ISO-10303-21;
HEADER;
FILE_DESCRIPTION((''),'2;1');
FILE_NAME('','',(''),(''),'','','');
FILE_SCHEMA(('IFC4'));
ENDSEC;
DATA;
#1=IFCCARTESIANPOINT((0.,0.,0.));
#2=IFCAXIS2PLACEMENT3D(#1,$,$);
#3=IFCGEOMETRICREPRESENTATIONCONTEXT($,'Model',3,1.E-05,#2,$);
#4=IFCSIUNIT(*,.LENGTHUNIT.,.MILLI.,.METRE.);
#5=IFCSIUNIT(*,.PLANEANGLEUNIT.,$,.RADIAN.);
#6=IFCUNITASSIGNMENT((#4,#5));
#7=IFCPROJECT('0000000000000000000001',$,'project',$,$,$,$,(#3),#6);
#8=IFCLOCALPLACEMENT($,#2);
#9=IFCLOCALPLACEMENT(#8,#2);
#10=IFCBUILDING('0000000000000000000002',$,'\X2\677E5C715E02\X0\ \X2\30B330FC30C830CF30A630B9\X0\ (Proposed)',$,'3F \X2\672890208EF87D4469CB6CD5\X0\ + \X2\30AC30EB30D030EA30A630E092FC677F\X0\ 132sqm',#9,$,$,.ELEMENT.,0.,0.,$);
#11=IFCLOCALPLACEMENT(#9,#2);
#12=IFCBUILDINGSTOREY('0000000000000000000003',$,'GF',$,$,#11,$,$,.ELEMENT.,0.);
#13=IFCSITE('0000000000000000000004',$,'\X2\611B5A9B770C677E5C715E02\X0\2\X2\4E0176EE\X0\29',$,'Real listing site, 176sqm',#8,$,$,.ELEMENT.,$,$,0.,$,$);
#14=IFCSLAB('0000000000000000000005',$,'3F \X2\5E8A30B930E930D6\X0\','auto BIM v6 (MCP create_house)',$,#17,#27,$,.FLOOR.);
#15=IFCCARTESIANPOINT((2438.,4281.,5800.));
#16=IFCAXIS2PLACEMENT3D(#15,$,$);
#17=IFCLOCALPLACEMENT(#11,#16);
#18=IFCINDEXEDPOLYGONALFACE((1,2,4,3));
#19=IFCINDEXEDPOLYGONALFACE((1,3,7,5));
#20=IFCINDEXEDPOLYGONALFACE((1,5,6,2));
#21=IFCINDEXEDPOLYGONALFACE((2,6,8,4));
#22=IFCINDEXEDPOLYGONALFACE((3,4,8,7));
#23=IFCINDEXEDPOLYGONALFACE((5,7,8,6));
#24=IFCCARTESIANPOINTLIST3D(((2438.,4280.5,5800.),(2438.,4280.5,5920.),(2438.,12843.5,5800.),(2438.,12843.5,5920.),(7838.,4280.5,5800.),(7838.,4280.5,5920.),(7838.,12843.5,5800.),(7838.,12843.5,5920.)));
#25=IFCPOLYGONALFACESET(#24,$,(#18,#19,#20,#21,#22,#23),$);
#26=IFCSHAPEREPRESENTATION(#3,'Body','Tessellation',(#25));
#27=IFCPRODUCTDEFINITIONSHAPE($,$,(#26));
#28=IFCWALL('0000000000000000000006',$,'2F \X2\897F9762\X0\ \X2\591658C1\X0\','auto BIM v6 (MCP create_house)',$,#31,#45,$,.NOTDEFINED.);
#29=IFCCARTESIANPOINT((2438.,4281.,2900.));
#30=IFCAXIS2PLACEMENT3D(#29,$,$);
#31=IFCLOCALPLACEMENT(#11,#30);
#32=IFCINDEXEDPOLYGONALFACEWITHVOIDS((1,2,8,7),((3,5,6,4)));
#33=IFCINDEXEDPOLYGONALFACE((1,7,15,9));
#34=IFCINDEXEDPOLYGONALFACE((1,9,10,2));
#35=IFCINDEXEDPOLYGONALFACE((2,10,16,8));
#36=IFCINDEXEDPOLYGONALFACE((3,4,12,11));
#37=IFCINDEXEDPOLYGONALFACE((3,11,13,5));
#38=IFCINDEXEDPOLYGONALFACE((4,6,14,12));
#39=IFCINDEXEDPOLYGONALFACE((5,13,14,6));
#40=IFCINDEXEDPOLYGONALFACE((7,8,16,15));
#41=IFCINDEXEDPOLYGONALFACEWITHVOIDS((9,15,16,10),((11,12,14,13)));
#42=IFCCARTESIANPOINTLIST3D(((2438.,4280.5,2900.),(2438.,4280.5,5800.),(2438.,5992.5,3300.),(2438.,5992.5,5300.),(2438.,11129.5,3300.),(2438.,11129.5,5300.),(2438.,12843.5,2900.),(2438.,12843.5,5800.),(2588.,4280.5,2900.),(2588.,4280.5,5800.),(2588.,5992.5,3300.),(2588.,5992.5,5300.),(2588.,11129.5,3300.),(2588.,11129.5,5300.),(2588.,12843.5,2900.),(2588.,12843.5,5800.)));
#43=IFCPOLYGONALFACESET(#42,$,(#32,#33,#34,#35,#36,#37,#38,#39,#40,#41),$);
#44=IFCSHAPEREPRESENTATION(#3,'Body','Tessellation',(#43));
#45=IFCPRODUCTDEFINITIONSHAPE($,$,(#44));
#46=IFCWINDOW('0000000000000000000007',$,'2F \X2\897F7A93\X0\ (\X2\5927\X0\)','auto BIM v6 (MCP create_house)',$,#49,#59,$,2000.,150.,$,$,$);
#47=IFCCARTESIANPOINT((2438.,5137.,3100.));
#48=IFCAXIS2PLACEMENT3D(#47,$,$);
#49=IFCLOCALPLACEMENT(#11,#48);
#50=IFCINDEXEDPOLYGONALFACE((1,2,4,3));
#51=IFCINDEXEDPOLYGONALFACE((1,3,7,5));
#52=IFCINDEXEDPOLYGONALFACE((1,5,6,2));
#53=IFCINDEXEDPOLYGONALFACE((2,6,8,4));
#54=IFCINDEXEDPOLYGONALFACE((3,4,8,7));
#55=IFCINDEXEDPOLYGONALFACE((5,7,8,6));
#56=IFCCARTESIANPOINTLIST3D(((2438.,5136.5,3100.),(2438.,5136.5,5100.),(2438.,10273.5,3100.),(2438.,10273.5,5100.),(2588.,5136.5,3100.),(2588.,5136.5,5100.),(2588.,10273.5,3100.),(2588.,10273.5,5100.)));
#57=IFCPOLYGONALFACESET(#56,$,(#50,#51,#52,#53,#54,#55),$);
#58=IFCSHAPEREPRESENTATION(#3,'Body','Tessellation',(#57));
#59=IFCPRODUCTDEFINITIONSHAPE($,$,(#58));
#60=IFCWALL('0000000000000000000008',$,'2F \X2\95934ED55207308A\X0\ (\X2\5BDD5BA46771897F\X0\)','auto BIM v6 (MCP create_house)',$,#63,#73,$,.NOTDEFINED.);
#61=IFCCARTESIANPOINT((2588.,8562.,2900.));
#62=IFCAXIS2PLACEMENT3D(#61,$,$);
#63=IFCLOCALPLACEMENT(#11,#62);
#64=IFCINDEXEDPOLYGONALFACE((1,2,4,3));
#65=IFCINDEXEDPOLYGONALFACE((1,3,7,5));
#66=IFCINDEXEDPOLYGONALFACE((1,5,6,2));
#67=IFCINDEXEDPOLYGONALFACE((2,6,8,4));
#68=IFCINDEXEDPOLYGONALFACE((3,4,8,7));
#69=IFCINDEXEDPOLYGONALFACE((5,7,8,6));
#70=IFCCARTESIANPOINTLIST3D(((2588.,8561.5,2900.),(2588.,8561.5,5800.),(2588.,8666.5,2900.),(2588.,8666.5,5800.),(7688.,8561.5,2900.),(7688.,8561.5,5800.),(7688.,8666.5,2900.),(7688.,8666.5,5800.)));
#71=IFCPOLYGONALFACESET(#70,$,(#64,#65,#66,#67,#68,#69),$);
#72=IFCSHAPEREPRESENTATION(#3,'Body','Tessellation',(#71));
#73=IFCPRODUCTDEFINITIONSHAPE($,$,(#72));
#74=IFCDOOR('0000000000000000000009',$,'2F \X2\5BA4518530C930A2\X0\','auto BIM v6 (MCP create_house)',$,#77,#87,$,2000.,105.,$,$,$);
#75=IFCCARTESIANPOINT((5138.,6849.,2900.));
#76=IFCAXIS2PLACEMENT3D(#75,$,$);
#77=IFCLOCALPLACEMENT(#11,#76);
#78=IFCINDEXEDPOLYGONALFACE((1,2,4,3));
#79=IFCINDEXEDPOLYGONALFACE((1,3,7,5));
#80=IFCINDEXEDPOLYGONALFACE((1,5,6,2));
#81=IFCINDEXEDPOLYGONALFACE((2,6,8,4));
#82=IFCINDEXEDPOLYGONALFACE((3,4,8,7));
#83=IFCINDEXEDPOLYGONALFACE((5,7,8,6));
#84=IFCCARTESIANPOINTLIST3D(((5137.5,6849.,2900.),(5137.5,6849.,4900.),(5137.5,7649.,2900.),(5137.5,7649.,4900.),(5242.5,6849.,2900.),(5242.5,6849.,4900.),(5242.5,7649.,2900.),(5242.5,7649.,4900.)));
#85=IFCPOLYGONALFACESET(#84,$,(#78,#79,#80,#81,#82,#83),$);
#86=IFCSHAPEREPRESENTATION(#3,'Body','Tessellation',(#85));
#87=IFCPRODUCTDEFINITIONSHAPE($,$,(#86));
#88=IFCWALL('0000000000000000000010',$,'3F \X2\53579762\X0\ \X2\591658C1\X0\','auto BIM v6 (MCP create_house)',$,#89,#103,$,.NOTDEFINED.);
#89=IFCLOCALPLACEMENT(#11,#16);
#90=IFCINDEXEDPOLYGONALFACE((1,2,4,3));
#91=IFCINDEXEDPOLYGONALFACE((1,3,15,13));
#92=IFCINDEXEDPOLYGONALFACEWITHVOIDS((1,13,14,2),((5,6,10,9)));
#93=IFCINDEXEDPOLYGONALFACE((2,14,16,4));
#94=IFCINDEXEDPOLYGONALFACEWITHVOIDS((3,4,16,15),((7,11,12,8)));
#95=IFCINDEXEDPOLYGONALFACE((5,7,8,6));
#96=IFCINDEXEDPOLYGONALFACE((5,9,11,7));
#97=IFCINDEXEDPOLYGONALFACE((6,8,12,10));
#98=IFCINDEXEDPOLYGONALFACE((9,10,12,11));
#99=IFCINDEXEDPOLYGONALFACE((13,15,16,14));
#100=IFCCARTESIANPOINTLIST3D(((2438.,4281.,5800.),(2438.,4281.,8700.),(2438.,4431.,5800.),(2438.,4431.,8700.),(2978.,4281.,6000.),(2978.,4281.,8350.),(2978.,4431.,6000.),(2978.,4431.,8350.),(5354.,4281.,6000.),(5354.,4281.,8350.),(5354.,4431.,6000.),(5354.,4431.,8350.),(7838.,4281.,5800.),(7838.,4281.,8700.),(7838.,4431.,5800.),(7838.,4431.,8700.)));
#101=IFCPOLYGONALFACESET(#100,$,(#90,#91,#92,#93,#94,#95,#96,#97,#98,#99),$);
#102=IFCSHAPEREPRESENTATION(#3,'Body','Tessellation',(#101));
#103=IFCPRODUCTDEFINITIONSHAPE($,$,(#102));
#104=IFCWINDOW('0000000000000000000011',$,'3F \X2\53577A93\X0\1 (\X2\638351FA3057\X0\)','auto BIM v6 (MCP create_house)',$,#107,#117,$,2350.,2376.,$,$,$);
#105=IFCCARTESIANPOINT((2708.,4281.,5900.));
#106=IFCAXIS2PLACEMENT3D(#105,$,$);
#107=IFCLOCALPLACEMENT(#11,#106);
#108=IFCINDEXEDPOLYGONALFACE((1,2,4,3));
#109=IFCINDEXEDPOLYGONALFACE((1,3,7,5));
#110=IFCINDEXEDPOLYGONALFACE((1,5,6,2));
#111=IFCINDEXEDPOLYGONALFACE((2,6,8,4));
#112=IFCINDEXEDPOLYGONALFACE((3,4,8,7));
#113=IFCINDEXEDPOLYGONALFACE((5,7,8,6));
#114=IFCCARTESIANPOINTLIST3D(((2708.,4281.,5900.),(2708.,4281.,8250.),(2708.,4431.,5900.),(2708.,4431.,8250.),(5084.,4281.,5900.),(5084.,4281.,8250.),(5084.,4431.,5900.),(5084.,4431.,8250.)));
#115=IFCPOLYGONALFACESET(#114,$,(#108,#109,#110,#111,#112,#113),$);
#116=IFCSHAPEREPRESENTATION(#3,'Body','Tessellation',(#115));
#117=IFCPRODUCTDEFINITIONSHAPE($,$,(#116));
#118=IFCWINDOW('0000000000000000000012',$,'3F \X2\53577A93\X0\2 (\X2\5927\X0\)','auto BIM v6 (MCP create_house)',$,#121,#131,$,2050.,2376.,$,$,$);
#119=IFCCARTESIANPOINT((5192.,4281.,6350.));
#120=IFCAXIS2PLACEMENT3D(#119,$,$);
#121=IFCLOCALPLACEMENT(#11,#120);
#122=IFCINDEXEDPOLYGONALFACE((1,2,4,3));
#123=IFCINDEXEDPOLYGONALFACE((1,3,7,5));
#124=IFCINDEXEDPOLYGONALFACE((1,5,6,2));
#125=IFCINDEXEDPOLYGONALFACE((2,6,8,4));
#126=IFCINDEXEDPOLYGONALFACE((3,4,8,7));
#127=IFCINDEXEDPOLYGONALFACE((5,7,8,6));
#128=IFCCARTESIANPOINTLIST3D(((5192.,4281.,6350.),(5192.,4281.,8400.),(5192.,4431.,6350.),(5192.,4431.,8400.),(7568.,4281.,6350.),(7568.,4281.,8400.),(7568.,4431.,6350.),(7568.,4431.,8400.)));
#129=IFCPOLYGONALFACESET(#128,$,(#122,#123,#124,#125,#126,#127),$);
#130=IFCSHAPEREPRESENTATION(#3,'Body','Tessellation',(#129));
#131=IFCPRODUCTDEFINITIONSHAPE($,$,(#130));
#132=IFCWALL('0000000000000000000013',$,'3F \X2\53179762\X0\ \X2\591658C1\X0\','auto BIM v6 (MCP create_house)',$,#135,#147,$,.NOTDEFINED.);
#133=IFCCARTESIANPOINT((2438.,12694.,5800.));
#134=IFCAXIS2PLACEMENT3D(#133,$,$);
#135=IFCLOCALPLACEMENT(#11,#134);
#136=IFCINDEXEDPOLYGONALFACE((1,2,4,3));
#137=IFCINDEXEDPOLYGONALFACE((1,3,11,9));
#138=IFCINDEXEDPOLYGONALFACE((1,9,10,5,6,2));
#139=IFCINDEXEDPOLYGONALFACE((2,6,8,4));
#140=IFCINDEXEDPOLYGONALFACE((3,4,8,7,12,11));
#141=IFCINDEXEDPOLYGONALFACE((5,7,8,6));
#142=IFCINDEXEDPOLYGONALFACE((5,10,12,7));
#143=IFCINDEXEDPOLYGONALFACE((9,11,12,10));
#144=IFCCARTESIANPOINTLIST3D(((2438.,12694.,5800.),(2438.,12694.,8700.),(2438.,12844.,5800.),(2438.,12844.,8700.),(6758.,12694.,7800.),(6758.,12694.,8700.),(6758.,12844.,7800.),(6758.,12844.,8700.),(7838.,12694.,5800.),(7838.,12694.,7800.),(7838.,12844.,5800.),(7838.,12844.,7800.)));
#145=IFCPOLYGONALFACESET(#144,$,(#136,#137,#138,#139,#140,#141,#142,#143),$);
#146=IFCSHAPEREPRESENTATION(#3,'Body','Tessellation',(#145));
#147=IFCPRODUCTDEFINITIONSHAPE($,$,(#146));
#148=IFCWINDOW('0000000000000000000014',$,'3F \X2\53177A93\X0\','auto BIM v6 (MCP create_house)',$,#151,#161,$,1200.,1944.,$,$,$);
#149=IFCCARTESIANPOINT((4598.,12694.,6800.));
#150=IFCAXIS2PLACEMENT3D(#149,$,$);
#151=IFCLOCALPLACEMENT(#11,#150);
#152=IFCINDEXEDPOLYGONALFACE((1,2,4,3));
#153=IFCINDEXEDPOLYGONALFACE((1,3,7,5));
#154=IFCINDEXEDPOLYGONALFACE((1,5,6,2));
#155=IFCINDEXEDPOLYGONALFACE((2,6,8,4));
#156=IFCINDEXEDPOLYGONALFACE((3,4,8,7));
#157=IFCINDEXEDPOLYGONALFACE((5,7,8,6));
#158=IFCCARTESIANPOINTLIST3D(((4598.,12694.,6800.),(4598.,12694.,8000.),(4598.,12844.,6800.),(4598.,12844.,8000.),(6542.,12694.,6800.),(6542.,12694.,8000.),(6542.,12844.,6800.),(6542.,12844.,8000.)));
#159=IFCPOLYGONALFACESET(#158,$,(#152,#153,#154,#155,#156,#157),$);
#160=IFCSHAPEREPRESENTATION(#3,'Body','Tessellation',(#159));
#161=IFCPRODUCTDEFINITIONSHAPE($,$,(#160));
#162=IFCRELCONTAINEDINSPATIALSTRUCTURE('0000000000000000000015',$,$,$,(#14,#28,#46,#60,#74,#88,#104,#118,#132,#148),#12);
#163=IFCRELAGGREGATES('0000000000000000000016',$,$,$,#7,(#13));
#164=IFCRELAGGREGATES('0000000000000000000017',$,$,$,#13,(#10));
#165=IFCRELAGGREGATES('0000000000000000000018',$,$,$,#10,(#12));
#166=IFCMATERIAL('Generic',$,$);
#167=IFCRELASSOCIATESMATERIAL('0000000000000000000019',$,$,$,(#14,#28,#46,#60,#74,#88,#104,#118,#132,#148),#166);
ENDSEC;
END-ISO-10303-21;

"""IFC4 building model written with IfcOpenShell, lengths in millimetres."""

from ifc_helpers import new_model, si_unit, frame, frame_2d, origin, place, context, project, spatial, rectangle, extrude, material, element, fill, save


model = new_model("IFC4")

# Units and contexts
model_context = context("Model", 3, precision=1e-05, world=origin())
ifc_project = project(units=[si_unit("LENGTHUNIT", "METRE", prefix="MILLI"), si_unit("PLANEANGLEUNIT", "RADIAN")], contexts=[model_context])

# Site, building, storey
site_placement = place(None, origin())
site = spatial("IfcSite", under=ifc_project, at=site_placement, Name="愛媛県松山市2丁目29", ObjectType="Real listing site, 176sqm", CompositionType="ELEMENT", RefElevation=0.0)
building_placement = place(site_placement, origin())
building = spatial("IfcBuilding", under=site, at=building_placement, Name="松山市 コートハウス (Proposed)", ObjectType="3F 木造軸組構法 + ガルバリウム鋼板 132sqm", CompositionType="ELEMENT", ElevationOfRefHeight=0.0, ElevationOfTerrain=0.0)
storey_placement = place(building_placement, origin())
storey = spatial("IfcBuildingStorey", under=building, at=storey_placement, Name="GF", CompositionType="ELEMENT", Elevation=0.0)

# Slab
ifc_material = material(Name="Generic")
slab_placement = place(storey_placement, frame((2438.0, 4281.0, 5800.0)))
element("IfcSlab", 1, at=slab_placement, inside=storey, material=ifc_material, Name="3F 床スラブ", Description="auto BIM v6 (MCP create_house)", PredefinedType="FLOOR", context=model_context, shape_type="SweptSolid", body=[
    extrude(rectangle(XDim=5400.0, YDim=8563.0, at=frame_2d((2700.0, 4281.0))), frame((2438.0, 4281.0, 5800.0)), (0.0, 0.0, 1.0), 120.0),
])

# Wall, opening, window
wall_1_placement = place(storey_placement, frame((2438.0, 4281.0, 2900.0)))
wall_1 = element("IfcWall", 2, at=wall_1_placement, inside=storey, material=ifc_material, Name="2F 西面 外壁", Description="auto BIM v6 (MCP create_house)", PredefinedType="NOTDEFINED", context=model_context, shape_type="SweptSolid", body=[
    extrude(rectangle(XDim=150.0, YDim=8563.0, at=frame_2d((75.0, 4281.0))), frame((2438.0, 4281.0, 2900.0)), (0.0, 0.0, 1.0), 2900.0),
])
opening_1_placement = place(storey_placement, frame((2438.0, 5137.0, 3100.0)))
opening_1 = element("IfcOpeningElement", 3, at=opening_1_placement, cuts=wall_1, PredefinedType="NOTDEFINED", context=model_context, shape_type="SweptSolid", body=[
    extrude(rectangle(XDim=150.0, YDim=5137.0, at=frame_2d((75.0, 2568.0))), frame((2438.0, 5137.0, 3100.0)), (0.0, 0.0, 1.0), 2000.0),
])
window_1_placement = place(storey_placement, frame((2438.0, 5137.0, 3100.0)))
window_1 = element("IfcWindow", 4, at=window_1_placement, inside=storey, material=ifc_material, Name="2F 西窓 (大)", Description="auto BIM v6 (MCP create_house)", OverallHeight=2000.0, OverallWidth=150.0, context=model_context, shape_type="SweptSolid", body=[
    extrude(rectangle(XDim=150.0, YDim=5137.0, at=frame_2d((75.0, 2568.0))), frame((2438.0, 5137.0, 3100.0)), (0.0, 0.0, 1.0), 2000.0),
])
fill(opening_1, window_1)

# Wall
wall_2_placement = place(storey_placement, frame((2588.0, 8562.0, 2900.0)))
element("IfcWall", 5, at=wall_2_placement, inside=storey, material=ifc_material, Name="2F 間仕切り (寝室東西)", Description="auto BIM v6 (MCP create_house)", PredefinedType="NOTDEFINED", context=model_context, shape_type="SweptSolid", body=[
    extrude(rectangle(XDim=5100.0, YDim=105.0, at=frame_2d((2550.0, 52.0))), frame((2588.0, 8562.0, 2900.0)), (0.0, 0.0, 1.0), 2900.0),
])

# Door
door_1_placement = place(storey_placement, frame((5138.0, 6849.0, 2900.0)))
element("IfcDoor", 6, at=door_1_placement, inside=storey, material=ifc_material, Name="2F 室内ドア", Description="auto BIM v6 (MCP create_house)", OverallHeight=2000.0, OverallWidth=105.0, context=model_context, shape_type="SweptSolid", body=[
    extrude(rectangle(XDim=105.0, YDim=800.0, at=frame_2d((52.0, 400.0))), frame((5138.0, 6849.0, 2900.0)), (0.0, 0.0, 1.0), 2000.0),
])

# Wall, openings, windows
wall_3_placement = place(storey_placement, frame((2438.0, 4281.0, 5800.0)))
wall_3 = element("IfcWall", 7, at=wall_3_placement, inside=storey, material=ifc_material, Name="3F 南面 外壁", Description="auto BIM v6 (MCP create_house)", PredefinedType="NOTDEFINED", context=model_context, shape_type="SweptSolid", body=[
    extrude(rectangle(XDim=5400.0, YDim=150.0, at=frame_2d((2700.0, 75.0))), frame((2438.0, 4281.0, 5800.0)), (0.0, 0.0, 1.0), 2900.0),
])
opening_2_placement = place(storey_placement, frame((2708.0, 4281.0, 5900.0)))
opening_2 = element("IfcOpeningElement", 8, at=opening_2_placement, cuts=wall_3, PredefinedType="NOTDEFINED", context=model_context, shape_type="SweptSolid", body=[
    extrude(rectangle(XDim=2376.0, YDim=150.0, at=frame_2d((1188.0, 75.0))), frame((2708.0, 4281.0, 5900.0)), (0.0, 0.0, 1.0), 2350.0),
])
opening_3_placement = place(storey_placement, frame((5192.0, 4281.0, 6350.0)))
opening_3 = element("IfcOpeningElement", 9, at=opening_3_placement, cuts=wall_3, PredefinedType="NOTDEFINED", context=model_context, shape_type="SweptSolid", body=[
    extrude(rectangle(XDim=2376.0, YDim=150.0, at=frame_2d((1188.0, 75.0))), frame((5192.0, 4281.0, 6350.0)), (0.0, 0.0, 1.0), 2050.0),
])
window_2_placement = place(storey_placement, frame((2708.0, 4281.0, 5900.0)))
window_2 = element("IfcWindow", 10, at=window_2_placement, inside=storey, material=ifc_material, Name="3F 南窓1 (掃出し)", Description="auto BIM v6 (MCP create_house)", OverallHeight=2350.0, OverallWidth=2376.0, context=model_context, shape_type="SweptSolid", body=[
    extrude(rectangle(XDim=2376.0, YDim=150.0, at=frame_2d((1188.0, 75.0))), frame((2708.0, 4281.0, 5900.0)), (0.0, 0.0, 1.0), 2350.0),
])
fill(opening_2, window_2)
window_3_placement = place(storey_placement, frame((5192.0, 4281.0, 6350.0)))
window_3 = element("IfcWindow", 11, at=window_3_placement, inside=storey, material=ifc_material, Name="3F 南窓2 (大)", Description="auto BIM v6 (MCP create_house)", OverallHeight=2050.0, OverallWidth=2376.0, context=model_context, shape_type="SweptSolid", body=[
    extrude(rectangle(XDim=2376.0, YDim=150.0, at=frame_2d((1188.0, 75.0))), frame((5192.0, 4281.0, 6350.0)), (0.0, 0.0, 1.0), 2050.0),
])
fill(opening_3, window_3)

# Wall, opening, window
wall_4_placement = place(storey_placement, frame((2438.0, 12694.0, 5800.0)))
wall_4 = element("IfcWall", 12, at=wall_4_placement, inside=storey, material=ifc_material, Name="3F 北面 外壁", Description="auto BIM v6 (MCP create_house)", PredefinedType="NOTDEFINED", context=model_context, shape_type="SweptSolid", body=[
    extrude(rectangle(XDim=5400.0, YDim=150.0, at=frame_2d((2700.0, 75.0))), frame((2438.0, 12694.0, 5800.0)), (0.0, 0.0, 1.0), 2900.0),
])
opening_4_placement = place(storey_placement, frame((4598.0, 12694.0, 6800.0)))
opening_4 = element("IfcOpeningElement", 13, at=opening_4_placement, cuts=wall_4, PredefinedType="NOTDEFINED", context=model_context, shape_type="SweptSolid", body=[
    extrude(rectangle(XDim=1944.0, YDim=150.0, at=frame_2d((972.0, 75.0))), frame((4598.0, 12694.0, 6800.0)), (0.0, 0.0, 1.0), 1200.0),
])
window_4_placement = place(storey_placement, frame((4598.0, 12694.0, 6800.0)))
window_4 = element("IfcWindow", 14, at=window_4_placement, inside=storey, material=ifc_material, Name="3F 北窓", Description="auto BIM v6 (MCP create_house)", OverallHeight=1200.0, OverallWidth=1944.0, context=model_context, shape_type="SweptSolid", body=[
    extrude(rectangle(XDim=1944.0, YDim=150.0, at=frame_2d((972.0, 75.0))), frame((4598.0, 12694.0, 6800.0)), (0.0, 0.0, 1.0), 1200.0),
])
fill(opening_4, window_4)

save(model, "model.ifc")
